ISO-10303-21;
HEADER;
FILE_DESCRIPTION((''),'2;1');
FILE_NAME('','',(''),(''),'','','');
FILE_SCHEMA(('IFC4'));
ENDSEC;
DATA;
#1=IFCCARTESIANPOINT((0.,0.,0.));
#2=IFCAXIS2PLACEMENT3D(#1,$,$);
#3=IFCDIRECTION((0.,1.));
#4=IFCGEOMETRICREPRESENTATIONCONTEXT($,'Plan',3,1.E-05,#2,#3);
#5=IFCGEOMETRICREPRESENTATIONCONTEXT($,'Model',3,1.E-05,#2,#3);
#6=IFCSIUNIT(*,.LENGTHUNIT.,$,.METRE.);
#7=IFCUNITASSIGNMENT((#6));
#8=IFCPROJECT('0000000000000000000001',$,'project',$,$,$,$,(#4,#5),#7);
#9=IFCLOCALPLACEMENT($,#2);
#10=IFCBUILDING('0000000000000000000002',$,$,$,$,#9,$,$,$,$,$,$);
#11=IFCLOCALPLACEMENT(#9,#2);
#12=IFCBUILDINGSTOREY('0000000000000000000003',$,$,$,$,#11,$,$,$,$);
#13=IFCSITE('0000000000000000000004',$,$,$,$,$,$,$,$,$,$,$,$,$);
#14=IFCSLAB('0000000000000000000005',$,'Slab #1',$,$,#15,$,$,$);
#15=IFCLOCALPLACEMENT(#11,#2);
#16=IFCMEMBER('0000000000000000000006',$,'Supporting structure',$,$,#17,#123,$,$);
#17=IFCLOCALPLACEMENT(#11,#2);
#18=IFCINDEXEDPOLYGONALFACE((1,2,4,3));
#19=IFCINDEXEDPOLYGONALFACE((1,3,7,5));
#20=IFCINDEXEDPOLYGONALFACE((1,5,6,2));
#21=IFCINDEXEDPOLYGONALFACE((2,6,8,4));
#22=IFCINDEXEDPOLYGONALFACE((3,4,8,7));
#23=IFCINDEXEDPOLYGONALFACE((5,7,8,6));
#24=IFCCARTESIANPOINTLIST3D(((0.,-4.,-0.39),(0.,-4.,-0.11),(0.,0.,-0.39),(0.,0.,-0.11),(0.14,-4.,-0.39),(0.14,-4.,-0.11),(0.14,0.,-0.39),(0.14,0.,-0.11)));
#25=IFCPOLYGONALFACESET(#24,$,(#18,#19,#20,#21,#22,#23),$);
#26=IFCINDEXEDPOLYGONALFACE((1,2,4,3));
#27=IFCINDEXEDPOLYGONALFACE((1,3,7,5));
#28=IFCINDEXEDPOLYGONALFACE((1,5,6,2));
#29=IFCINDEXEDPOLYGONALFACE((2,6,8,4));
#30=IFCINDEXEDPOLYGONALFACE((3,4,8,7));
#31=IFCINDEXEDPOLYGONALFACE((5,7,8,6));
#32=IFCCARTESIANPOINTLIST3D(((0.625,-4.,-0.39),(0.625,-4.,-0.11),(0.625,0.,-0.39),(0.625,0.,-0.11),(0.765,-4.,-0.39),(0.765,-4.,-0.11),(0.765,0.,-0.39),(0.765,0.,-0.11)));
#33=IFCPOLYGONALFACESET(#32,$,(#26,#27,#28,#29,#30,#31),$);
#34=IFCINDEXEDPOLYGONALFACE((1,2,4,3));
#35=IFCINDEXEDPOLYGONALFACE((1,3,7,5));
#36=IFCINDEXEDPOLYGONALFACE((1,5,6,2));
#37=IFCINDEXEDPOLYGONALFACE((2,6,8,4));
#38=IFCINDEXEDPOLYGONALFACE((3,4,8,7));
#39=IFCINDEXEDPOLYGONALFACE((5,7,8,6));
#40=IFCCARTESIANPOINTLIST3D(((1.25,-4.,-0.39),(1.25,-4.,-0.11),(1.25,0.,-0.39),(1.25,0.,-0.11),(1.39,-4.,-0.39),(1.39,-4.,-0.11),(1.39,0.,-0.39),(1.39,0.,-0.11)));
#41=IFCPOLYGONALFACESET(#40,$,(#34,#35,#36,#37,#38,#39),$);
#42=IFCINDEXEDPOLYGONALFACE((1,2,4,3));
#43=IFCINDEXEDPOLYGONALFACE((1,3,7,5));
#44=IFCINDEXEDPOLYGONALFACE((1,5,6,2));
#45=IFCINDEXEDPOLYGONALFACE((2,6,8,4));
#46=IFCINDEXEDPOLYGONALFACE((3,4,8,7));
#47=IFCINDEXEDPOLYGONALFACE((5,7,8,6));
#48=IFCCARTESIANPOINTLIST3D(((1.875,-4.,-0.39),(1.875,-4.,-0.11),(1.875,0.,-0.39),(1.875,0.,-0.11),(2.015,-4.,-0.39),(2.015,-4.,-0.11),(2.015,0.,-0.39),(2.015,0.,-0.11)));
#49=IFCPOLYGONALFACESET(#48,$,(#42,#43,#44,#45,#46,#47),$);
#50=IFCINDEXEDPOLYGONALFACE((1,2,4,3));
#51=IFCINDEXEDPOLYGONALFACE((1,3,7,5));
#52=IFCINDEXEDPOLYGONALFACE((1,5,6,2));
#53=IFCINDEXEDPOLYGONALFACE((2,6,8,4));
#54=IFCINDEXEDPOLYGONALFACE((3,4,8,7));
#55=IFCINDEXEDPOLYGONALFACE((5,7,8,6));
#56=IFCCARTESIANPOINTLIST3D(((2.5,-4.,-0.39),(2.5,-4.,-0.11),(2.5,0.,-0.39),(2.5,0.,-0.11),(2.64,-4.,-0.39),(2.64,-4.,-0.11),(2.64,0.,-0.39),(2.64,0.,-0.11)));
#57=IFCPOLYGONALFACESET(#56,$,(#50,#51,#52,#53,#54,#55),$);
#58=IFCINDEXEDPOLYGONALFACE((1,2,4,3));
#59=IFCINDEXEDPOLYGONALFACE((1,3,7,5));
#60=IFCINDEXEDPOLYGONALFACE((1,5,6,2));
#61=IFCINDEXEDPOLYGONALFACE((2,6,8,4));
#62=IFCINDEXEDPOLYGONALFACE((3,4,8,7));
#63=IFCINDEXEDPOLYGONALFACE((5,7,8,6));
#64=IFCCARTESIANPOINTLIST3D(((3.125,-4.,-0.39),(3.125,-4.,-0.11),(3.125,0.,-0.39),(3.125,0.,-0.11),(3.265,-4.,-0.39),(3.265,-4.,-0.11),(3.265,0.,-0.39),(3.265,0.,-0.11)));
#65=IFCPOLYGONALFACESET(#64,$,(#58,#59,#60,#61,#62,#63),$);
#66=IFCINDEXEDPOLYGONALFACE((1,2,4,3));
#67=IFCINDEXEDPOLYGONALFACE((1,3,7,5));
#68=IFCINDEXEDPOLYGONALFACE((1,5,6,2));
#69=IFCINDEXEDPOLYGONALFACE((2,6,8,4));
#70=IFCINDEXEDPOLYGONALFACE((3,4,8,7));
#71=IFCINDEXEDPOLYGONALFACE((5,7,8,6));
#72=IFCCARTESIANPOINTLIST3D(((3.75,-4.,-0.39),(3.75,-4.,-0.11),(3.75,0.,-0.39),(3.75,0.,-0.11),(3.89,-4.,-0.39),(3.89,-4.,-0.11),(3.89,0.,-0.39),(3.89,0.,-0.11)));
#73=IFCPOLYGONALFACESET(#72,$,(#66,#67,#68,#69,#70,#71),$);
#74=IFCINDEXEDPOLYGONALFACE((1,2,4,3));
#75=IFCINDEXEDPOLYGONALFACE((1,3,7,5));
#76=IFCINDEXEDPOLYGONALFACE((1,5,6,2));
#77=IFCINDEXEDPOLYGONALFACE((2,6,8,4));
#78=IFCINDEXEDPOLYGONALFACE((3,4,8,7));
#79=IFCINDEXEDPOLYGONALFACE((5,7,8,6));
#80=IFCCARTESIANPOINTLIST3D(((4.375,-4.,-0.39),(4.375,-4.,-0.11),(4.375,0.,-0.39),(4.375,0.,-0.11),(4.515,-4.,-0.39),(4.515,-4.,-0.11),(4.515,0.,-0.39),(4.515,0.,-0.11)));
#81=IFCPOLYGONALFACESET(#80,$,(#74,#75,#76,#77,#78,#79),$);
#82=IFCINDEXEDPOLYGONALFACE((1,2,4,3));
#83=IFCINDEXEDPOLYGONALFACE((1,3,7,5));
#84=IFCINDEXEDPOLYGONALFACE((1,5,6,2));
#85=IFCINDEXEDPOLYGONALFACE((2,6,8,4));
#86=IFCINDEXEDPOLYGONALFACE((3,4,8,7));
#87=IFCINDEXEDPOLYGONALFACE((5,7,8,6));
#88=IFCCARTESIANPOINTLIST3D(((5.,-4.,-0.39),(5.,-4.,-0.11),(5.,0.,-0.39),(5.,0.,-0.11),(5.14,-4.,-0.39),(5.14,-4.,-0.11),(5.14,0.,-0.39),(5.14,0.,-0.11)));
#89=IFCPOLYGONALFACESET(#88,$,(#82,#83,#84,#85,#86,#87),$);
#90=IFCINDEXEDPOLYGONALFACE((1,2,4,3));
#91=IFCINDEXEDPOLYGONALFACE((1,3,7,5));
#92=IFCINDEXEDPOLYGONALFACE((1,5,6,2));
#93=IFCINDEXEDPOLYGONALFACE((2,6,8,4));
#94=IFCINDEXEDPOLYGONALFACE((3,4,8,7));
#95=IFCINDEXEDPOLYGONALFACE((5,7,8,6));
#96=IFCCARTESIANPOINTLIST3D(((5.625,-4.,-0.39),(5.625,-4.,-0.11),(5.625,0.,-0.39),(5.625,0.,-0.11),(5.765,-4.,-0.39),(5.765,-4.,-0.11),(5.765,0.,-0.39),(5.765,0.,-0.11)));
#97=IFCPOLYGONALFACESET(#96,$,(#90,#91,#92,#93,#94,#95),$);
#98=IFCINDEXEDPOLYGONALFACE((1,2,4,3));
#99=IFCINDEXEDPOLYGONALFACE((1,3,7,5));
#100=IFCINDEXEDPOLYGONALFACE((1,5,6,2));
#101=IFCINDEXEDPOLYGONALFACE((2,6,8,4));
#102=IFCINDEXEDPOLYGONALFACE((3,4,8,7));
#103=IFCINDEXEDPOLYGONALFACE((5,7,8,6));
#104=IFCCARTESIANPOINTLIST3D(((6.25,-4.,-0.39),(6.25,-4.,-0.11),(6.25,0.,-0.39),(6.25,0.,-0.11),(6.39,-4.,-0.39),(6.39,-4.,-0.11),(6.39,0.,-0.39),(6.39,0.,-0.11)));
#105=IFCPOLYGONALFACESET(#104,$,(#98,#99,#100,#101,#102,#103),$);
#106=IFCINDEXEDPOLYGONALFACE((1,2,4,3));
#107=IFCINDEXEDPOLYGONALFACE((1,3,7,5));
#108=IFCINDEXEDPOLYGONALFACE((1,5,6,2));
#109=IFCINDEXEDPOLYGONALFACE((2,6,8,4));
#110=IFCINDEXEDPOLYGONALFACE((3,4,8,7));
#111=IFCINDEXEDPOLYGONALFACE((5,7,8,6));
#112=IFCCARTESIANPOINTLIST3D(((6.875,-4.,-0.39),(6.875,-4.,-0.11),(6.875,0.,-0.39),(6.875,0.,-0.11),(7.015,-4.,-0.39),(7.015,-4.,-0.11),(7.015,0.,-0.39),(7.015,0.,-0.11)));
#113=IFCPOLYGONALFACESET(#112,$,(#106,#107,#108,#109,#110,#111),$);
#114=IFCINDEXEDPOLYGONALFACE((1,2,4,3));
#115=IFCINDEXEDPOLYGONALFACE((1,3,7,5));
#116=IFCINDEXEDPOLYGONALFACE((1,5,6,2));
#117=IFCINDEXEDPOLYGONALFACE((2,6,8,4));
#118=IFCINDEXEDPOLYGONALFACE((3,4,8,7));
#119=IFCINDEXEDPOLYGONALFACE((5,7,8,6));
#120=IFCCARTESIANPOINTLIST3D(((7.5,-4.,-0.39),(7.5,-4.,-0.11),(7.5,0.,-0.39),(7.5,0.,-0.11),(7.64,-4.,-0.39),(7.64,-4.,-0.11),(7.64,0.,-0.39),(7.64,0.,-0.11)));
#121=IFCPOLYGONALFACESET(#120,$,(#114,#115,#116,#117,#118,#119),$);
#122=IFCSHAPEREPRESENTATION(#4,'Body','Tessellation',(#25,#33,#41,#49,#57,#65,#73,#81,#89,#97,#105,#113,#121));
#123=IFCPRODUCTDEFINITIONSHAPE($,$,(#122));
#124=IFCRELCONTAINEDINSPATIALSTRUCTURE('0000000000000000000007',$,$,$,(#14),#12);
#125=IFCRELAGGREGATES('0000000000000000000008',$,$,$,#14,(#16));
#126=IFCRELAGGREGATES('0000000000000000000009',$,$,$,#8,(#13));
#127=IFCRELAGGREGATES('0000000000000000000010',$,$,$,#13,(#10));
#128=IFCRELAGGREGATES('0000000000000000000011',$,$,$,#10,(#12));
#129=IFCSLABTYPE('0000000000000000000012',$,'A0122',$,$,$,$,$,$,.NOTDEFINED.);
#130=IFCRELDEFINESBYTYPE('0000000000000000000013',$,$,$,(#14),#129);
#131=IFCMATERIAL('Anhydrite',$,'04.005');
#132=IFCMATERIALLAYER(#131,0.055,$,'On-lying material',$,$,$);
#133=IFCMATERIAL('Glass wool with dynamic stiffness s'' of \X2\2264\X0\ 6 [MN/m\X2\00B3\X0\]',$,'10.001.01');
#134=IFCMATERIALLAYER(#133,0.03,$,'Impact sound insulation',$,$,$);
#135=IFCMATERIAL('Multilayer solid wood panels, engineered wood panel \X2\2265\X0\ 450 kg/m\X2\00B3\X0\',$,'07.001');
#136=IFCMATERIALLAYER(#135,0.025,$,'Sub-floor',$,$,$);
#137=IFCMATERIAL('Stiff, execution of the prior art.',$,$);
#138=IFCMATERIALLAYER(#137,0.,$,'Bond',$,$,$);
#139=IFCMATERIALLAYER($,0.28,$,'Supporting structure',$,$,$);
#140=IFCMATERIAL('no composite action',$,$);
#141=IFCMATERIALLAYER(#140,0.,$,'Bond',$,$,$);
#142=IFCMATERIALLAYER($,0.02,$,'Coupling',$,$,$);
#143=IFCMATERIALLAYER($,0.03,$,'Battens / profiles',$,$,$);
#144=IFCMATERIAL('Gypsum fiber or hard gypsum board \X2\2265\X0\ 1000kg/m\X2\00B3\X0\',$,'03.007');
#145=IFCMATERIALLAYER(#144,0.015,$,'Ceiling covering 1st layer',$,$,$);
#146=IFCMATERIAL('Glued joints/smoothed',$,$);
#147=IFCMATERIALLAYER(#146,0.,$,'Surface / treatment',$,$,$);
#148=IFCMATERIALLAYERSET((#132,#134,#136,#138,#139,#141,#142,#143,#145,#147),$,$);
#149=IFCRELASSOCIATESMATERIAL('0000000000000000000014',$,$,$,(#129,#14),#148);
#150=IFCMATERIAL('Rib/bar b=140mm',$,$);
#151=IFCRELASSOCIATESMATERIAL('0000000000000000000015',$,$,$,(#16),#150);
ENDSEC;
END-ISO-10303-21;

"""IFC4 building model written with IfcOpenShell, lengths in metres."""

from ifc_helpers import new_model, si_unit, direction, frame, frame_2d, origin, place, context, project, spatial, rectangle, extrude, material, layer, layer_set, type_object, element, aggregate, save


model = new_model("IFC4")

# Units and contexts
plan_context = context("Plan", 3, precision=1e-05, world=origin(), true_north=direction((0.0, 1.0)))
model_context = context("Model", 3, precision=1e-05, world=origin(), true_north=direction((0.0, 1.0)))
ifc_project = project(units=[si_unit("LENGTHUNIT", "METRE")], contexts=[plan_context, model_context])

# Site, building, storey
site = spatial("IfcSite", under=ifc_project)
building_placement = place(None, origin())
building = spatial("IfcBuilding", under=site, at=building_placement)
storey_placement = place(building_placement, origin())
storey = spatial("IfcBuildingStorey", under=building, at=storey_placement)

# Slab, member
ifc_material_1 = material(Name="Anhydrite", Category="04.005")
ifc_layer_1 = layer(ifc_material_1, 0.055, Name="On-lying material")
ifc_material_2 = material(Name="Glass wool with dynamic stiffness s' of ≤ 6 [MN/m³]", Category="10.001.01")
ifc_layer_2 = layer(ifc_material_2, 0.03, Name="Impact sound insulation")
ifc_material_3 = material(Name="Multilayer solid wood panels, engineered wood panel ≥ 450 kg/m³", Category="07.001")
ifc_layer_3 = layer(ifc_material_3, 0.025, Name="Sub-floor")
ifc_material_4 = material(Name="Stiff, execution of the prior art.")
ifc_layer_4 = layer(ifc_material_4, 0.0, Name="Bond")
ifc_layer_5 = layer(None, 0.28, Name="Supporting structure")
ifc_material_5 = material(Name="no composite action")
ifc_layer_6 = layer(ifc_material_5, 0.0, Name="Bond")
ifc_layer_7 = layer(None, 0.02, Name="Coupling")
ifc_layer_8 = layer(None, 0.03, Name="Battens / profiles")
ifc_material_6 = material(Name="Gypsum fiber or hard gypsum board ≥ 1000kg/m³", Category="03.007")
ifc_layer_9 = layer(ifc_material_6, 0.015, Name="Ceiling covering 1st layer")
ifc_material_7 = material(Name="Glued joints/smoothed")
ifc_layer_10 = layer(ifc_material_7, 0.0, Name="Surface / treatment")
ifc_layer_set = layer_set([ifc_layer_1, ifc_layer_2, ifc_layer_3, ifc_layer_4, ifc_layer_5, ifc_layer_6, ifc_layer_7, ifc_layer_8, ifc_layer_9, ifc_layer_10])
slab_type = type_object("IfcSlabType", Name="A0122", PredefinedType="NOTDEFINED", material=ifc_layer_set)
slab_placement = place(None, frame((0.0, 0.0, 0.0), z_axis=(0.0, 0.0, -1.0), x_axis=(1.0, 0.0, 0.0)))
slab = element("IfcSlab", 1, at=slab_placement, inside=storey, type_object=slab_type, material=ifc_layer_set, Name="Slab #1")
ifc_material_8 = material(Name="Rib/bar b=140mm")
member_1_placement = place(slab_placement, origin())
member_1 = element("IfcMember", 2, at=member_1_placement, material=ifc_material_8, Name="Supporting structure", context=plan_context, shape_type="SweptSolid", body=[
    extrude(rectangle(XDim=0.14, YDim=0.28, at=frame_2d((0.07, 0.14), x_axis=(1.0, 0.0))), frame((0.0, 4.0, 0.11), z_axis=(0.0, -1.0, 0.0), x_axis=(1.0, 0.0, 0.0)), (0.0, 0.0, 1.0), 4.0),
    extrude(rectangle(XDim=0.14, YDim=0.28, at=frame_2d((0.07, 0.14), x_axis=(1.0, 0.0))), frame((0.625, 4.0, 0.11), z_axis=(0.0, -1.0, 0.0), x_axis=(1.0, 0.0, 0.0)), (0.0, 0.0, 1.0), 4.0),
    extrude(rectangle(XDim=0.14, YDim=0.28, at=frame_2d((0.07, 0.14), x_axis=(1.0, 0.0))), frame((1.25, 4.0, 0.11), z_axis=(0.0, -1.0, 0.0), x_axis=(1.0, 0.0, 0.0)), (0.0, 0.0, 1.0), 4.0),
    extrude(rectangle(XDim=0.14, YDim=0.28, at=frame_2d((0.07, 0.14), x_axis=(1.0, 0.0))), frame((1.875, 4.0, 0.11), z_axis=(0.0, -1.0, 0.0), x_axis=(1.0, 0.0, 0.0)), (0.0, 0.0, 1.0), 4.0),
    extrude(rectangle(XDim=0.14, YDim=0.28, at=frame_2d((0.07, 0.14), x_axis=(1.0, 0.0))), frame((2.5, 4.0, 0.11), z_axis=(0.0, -1.0, 0.0), x_axis=(1.0, 0.0, 0.0)), (0.0, 0.0, 1.0), 4.0),
    extrude(rectangle(XDim=0.14, YDim=0.28, at=frame_2d((0.07, 0.14), x_axis=(1.0, 0.0))), frame((3.125, 4.0, 0.11), z_axis=(0.0, -1.0, 0.0), x_axis=(1.0, 0.0, 0.0)), (0.0, 0.0, 1.0), 4.0),
    extrude(rectangle(XDim=0.14, YDim=0.28, at=frame_2d((0.07, 0.14), x_axis=(1.0, 0.0))), frame((3.75, 4.0, 0.11), z_axis=(0.0, -1.0, 0.0), x_axis=(1.0, 0.0, 0.0)), (0.0, 0.0, 1.0), 4.0),
    extrude(rectangle(XDim=0.14, YDim=0.28, at=frame_2d((0.07, 0.14), x_axis=(1.0, 0.0))), frame((4.375, 4.0, 0.11), z_axis=(0.0, -1.0, 0.0), x_axis=(1.0, 0.0, 0.0)), (0.0, 0.0, 1.0), 4.0),
    extrude(rectangle(XDim=0.14, YDim=0.28, at=frame_2d((0.07, 0.14), x_axis=(1.0, 0.0))), frame((5.0, 4.0, 0.11), z_axis=(0.0, -1.0, 0.0), x_axis=(1.0, 0.0, 0.0)), (0.0, 0.0, 1.0), 4.0),
    extrude(rectangle(XDim=0.14, YDim=0.28, at=frame_2d((0.07, 0.14), x_axis=(1.0, 0.0))), frame((5.625, 4.0, 0.11), z_axis=(0.0, -1.0, 0.0), x_axis=(1.0, 0.0, 0.0)), (0.0, 0.0, 1.0), 4.0),
    extrude(rectangle(XDim=0.14, YDim=0.28, at=frame_2d((0.07, 0.14), x_axis=(1.0, 0.0))), frame((6.25, 4.0, 0.11), z_axis=(0.0, -1.0, 0.0), x_axis=(1.0, 0.0, 0.0)), (0.0, 0.0, 1.0), 4.0),
    extrude(rectangle(XDim=0.14, YDim=0.28, at=frame_2d((0.07, 0.14), x_axis=(1.0, 0.0))), frame((6.875, 4.0, 0.11), z_axis=(0.0, -1.0, 0.0), x_axis=(1.0, 0.0, 0.0)), (0.0, 0.0, 1.0), 4.0),
    extrude(rectangle(XDim=0.14, YDim=0.28, at=frame_2d((0.07, 0.14), x_axis=(1.0, 0.0))), frame((7.5, 4.0, 0.11), z_axis=(0.0, -1.0, 0.0), x_axis=(1.0, 0.0, 0.0)), (0.0, 0.0, 1.0), 4.0),
])
aggregate(slab, [member_1])

save(model, "model.ifc")
